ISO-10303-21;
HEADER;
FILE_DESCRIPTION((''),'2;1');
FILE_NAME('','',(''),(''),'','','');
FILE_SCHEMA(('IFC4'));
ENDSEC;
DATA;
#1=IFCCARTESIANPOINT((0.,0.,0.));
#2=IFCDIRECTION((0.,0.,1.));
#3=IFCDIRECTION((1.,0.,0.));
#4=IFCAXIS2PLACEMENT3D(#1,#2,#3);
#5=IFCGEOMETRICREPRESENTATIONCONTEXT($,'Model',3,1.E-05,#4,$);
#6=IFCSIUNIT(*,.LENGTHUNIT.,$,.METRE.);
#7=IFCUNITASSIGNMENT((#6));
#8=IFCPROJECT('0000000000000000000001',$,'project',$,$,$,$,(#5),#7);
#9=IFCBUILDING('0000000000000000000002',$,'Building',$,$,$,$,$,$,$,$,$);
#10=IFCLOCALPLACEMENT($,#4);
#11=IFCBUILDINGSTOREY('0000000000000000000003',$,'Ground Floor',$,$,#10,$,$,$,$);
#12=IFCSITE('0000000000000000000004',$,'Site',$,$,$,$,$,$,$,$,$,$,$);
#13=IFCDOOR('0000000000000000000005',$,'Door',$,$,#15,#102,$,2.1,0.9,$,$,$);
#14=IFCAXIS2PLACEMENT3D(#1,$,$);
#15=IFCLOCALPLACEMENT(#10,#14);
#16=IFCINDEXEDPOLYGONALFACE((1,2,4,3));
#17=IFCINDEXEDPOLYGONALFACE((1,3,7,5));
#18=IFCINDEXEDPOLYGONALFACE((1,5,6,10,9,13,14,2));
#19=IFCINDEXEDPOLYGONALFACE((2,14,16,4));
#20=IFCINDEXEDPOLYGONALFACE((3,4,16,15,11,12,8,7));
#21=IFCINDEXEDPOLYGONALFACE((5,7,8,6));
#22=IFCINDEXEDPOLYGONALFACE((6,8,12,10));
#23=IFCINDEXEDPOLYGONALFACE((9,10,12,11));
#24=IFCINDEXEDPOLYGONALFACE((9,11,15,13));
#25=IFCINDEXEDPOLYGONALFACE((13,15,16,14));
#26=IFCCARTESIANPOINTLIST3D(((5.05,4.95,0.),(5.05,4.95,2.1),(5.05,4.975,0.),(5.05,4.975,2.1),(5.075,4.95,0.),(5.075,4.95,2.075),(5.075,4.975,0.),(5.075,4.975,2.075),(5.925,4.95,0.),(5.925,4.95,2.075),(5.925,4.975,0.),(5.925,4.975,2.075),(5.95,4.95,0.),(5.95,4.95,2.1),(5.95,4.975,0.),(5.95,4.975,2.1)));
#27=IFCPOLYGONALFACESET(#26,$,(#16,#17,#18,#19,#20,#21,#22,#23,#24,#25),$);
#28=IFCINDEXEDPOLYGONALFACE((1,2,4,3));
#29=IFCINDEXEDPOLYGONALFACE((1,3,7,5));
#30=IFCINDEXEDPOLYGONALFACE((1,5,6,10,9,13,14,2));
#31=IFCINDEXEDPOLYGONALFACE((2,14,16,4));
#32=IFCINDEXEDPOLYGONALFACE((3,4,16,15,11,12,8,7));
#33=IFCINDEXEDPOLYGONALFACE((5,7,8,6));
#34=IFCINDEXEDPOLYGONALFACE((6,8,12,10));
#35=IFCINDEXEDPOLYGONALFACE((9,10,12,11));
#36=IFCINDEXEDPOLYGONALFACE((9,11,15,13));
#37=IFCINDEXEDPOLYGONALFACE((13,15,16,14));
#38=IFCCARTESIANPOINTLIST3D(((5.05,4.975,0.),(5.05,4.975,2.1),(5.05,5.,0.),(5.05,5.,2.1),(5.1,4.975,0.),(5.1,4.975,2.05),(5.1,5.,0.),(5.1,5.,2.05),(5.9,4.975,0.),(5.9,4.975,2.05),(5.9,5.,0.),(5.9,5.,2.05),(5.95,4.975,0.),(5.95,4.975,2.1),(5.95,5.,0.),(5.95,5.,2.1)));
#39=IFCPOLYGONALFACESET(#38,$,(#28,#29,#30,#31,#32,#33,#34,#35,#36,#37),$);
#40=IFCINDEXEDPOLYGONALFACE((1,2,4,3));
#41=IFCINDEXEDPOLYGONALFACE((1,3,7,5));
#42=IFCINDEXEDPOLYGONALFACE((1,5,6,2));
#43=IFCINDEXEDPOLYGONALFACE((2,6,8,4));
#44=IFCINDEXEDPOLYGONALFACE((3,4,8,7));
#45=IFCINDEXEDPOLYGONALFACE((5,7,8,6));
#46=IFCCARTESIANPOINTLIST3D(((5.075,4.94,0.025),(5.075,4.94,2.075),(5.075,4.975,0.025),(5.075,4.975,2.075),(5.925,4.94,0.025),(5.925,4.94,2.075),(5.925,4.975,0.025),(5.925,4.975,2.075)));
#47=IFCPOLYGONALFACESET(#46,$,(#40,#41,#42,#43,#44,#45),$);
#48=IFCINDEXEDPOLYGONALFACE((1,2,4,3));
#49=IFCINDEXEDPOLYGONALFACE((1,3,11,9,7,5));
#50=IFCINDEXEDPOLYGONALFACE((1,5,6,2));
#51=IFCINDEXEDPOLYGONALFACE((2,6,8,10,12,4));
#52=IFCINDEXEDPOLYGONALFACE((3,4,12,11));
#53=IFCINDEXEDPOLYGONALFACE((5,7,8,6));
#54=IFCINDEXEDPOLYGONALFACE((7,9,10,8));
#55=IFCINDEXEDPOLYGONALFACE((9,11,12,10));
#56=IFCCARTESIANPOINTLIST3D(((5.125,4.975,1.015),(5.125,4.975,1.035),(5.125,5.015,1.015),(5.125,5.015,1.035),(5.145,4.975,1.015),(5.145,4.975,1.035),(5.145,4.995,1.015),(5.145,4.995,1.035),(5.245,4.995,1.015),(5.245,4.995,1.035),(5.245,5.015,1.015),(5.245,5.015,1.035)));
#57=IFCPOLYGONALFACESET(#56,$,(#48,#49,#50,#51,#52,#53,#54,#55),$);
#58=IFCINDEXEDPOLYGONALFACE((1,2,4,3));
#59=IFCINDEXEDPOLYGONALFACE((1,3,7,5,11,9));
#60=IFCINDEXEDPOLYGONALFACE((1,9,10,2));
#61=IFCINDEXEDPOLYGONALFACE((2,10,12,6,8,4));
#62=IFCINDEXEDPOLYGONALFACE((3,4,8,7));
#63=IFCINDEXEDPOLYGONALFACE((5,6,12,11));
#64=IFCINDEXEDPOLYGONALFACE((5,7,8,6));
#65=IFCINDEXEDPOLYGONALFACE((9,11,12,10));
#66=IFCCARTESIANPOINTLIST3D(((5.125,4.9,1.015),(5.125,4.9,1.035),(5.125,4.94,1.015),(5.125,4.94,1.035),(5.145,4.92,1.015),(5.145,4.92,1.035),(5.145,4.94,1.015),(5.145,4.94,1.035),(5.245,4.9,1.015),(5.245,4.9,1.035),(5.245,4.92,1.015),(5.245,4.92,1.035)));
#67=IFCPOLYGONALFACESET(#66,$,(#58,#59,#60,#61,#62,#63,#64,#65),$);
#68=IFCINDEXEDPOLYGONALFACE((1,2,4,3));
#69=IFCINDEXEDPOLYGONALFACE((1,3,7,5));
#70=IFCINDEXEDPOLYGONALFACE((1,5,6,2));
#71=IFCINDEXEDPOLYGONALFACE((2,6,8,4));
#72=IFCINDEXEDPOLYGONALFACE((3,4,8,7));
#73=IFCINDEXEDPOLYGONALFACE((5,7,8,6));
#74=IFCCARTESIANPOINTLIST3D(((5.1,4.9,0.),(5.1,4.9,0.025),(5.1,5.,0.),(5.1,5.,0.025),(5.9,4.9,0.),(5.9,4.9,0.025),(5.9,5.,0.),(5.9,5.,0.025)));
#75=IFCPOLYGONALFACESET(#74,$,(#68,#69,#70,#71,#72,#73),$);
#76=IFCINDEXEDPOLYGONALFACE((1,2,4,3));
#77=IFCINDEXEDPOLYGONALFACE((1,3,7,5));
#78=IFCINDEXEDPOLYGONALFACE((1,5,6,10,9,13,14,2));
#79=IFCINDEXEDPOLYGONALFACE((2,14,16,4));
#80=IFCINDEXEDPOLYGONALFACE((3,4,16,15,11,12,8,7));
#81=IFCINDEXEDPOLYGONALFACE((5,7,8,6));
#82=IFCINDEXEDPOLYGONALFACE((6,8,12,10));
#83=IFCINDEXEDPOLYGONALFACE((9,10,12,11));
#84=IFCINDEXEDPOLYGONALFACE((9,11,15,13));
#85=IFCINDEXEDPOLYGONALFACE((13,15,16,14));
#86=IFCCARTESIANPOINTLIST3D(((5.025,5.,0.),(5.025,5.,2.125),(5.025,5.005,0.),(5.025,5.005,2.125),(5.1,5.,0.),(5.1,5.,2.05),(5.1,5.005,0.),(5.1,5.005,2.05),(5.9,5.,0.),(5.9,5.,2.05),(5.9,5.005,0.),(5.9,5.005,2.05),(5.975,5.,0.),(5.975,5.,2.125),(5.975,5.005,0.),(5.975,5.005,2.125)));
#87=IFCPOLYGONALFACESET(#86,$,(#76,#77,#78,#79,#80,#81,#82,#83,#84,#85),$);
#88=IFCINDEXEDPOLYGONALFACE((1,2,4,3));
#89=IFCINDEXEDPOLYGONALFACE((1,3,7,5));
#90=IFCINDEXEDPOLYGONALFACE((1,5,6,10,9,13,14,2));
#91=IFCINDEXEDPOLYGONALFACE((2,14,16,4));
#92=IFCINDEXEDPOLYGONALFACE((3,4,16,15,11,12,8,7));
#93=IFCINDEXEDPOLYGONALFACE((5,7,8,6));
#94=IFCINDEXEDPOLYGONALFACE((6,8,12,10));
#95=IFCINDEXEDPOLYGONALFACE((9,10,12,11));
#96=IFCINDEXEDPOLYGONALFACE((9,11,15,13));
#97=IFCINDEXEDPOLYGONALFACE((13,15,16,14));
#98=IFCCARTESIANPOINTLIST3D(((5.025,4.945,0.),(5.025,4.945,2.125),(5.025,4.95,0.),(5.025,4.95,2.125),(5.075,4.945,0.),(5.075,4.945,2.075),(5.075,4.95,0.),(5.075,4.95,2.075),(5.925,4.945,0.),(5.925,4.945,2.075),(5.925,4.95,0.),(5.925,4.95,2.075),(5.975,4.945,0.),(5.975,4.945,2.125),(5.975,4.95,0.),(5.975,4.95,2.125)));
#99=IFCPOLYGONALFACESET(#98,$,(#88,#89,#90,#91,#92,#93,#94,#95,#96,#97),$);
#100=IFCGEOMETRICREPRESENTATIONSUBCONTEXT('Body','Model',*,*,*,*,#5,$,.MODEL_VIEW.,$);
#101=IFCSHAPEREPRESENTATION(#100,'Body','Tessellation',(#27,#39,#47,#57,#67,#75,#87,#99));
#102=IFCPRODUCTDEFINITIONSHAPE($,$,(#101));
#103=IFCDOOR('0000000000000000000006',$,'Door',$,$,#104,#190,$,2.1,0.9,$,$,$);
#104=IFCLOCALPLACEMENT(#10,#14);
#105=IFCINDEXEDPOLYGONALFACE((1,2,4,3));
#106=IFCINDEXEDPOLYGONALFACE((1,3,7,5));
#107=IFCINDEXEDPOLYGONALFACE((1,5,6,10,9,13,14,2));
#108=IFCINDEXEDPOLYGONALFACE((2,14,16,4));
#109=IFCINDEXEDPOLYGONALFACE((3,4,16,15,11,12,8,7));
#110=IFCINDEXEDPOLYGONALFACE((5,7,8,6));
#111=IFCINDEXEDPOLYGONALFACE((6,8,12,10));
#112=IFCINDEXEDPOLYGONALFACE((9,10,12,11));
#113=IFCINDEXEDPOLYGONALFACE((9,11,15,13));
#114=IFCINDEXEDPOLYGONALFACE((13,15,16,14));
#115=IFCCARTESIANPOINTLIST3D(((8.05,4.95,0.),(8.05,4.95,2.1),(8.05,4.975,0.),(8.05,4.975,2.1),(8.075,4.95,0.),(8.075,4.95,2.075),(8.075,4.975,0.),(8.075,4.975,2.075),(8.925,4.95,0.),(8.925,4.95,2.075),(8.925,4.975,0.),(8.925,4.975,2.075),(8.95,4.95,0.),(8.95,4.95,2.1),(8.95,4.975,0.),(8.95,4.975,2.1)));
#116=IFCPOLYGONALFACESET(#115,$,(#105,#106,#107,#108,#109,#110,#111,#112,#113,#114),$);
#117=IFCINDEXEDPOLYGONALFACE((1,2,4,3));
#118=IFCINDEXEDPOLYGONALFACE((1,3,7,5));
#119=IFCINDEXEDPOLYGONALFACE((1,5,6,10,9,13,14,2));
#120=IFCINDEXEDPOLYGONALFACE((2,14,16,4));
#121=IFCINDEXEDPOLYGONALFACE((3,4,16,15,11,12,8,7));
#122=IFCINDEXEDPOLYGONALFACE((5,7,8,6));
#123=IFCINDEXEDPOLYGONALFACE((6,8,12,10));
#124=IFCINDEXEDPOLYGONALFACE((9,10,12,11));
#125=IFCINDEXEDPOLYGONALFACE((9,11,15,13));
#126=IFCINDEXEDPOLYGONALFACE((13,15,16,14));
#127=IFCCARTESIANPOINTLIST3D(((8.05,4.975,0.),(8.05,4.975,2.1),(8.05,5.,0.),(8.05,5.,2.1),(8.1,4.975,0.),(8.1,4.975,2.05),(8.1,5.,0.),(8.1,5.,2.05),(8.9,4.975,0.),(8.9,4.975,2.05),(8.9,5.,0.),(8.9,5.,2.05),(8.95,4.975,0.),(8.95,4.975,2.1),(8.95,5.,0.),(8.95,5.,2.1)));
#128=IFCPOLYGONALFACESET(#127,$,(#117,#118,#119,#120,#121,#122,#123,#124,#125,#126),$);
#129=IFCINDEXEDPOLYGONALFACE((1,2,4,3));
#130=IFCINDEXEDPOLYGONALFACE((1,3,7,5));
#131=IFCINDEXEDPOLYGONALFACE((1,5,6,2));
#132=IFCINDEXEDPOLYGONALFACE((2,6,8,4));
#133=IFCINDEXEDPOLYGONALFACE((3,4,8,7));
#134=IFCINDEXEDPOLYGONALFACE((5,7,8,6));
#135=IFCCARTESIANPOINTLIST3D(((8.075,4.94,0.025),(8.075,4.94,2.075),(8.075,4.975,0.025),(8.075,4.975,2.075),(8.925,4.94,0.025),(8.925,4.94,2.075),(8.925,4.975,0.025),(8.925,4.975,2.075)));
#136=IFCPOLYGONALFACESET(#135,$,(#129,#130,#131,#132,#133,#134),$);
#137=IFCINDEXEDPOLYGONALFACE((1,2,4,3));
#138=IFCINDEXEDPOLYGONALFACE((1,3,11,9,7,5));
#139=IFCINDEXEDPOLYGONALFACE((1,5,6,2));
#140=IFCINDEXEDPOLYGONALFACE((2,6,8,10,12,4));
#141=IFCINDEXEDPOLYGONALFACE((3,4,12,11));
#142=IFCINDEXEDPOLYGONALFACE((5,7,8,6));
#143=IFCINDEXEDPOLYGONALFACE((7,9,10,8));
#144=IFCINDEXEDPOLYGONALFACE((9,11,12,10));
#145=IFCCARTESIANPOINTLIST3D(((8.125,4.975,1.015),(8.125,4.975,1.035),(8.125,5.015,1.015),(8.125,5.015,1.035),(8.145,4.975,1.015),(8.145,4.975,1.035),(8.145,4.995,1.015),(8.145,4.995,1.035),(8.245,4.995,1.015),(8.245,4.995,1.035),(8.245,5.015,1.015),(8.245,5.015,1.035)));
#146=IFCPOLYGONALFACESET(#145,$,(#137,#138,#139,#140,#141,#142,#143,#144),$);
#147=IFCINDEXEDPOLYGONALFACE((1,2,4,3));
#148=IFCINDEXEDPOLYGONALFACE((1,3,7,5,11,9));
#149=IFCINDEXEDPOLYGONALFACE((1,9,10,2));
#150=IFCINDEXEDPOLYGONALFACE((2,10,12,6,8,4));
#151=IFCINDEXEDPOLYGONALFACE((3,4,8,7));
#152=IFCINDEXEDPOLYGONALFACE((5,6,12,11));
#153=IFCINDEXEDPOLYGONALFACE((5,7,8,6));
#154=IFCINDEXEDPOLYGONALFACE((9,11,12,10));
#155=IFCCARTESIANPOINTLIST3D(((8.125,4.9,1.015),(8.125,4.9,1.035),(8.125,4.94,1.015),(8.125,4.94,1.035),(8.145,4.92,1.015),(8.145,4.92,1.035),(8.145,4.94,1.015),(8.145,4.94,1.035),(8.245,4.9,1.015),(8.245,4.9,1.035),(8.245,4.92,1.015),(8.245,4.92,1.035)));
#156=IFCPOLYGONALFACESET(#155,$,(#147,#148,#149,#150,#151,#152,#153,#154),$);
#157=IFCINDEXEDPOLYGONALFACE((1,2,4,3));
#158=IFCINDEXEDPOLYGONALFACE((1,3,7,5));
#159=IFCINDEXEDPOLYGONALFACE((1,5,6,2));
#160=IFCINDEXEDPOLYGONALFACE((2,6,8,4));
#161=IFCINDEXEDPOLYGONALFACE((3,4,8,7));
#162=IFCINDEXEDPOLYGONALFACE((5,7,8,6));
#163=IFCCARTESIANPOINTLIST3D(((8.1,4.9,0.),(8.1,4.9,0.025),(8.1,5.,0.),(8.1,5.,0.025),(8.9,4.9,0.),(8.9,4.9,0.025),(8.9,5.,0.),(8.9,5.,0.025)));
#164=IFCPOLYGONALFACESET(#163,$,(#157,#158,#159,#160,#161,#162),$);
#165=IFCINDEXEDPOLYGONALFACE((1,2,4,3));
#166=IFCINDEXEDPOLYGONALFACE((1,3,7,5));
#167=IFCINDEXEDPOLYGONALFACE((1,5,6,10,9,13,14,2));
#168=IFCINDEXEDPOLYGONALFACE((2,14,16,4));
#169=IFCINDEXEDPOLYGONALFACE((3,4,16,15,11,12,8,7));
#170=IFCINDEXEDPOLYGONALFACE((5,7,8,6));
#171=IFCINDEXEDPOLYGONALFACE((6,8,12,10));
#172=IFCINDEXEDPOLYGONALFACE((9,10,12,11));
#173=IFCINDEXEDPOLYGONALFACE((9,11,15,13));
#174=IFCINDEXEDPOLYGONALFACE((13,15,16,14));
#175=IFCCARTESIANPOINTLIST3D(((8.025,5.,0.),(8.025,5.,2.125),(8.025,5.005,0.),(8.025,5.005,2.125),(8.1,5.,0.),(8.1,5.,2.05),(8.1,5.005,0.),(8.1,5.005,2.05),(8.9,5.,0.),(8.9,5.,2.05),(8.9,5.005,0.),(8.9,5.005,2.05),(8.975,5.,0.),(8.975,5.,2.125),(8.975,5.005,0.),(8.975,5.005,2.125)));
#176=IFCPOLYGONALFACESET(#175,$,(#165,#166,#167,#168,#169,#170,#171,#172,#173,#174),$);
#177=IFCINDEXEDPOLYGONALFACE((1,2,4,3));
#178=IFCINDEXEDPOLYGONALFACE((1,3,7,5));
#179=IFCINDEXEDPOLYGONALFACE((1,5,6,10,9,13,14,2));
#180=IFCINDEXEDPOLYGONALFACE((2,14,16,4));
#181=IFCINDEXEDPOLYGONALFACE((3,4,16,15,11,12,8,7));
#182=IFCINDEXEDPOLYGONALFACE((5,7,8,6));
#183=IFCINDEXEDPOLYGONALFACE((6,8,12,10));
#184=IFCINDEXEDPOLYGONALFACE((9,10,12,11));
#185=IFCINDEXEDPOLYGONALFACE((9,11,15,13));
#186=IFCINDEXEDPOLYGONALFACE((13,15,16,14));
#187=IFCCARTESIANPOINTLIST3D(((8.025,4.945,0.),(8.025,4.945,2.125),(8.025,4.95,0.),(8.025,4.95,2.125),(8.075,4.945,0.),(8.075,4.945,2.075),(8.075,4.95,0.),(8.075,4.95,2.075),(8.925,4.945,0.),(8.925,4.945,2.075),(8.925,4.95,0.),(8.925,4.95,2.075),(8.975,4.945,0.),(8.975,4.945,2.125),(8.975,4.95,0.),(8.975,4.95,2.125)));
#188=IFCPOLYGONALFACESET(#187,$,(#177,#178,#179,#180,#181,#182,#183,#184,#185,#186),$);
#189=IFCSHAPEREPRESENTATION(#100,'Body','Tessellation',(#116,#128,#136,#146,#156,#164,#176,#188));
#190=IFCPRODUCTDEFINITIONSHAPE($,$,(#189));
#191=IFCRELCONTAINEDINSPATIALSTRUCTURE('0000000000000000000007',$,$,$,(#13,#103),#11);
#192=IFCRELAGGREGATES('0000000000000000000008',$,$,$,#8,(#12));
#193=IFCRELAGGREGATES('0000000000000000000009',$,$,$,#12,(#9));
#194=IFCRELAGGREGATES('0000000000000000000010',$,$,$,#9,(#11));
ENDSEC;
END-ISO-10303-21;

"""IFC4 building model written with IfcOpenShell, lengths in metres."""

from ifc_helpers import new_model, si_unit, frame, origin_with_axes, place, context, subcontext, project, spatial, line, indexed_curve, outline, extrude, element, save


model = new_model("IFC4")

# Units and contexts
model_context = context("Model", 3, precision=1e-05, world=origin_with_axes())
body_context = subcontext(model_context, "Body", "Model", "MODEL_VIEW")
ifc_project = project(units=[si_unit("LENGTHUNIT", "METRE")], contexts=[model_context])

# Site, building, storey
site = spatial("IfcSite", under=ifc_project, Name="Site")
building = spatial("IfcBuilding", under=site, Name="Building")
storey_placement = place(None, origin_with_axes())
storey = spatial("IfcBuildingStorey", under=building, at=storey_placement, Name="Ground Floor")

# Doors
door_1_placement = place(storey_placement, frame((5.95, 5.0, 0.0), z_axis=(0.0, 0.0, 1.0), x_axis=(-1.0, 0.0, 0.0)))
element("IfcDoor", 1, at=door_1_placement, inside=storey, Name="Door", OverallHeight=2.1, OverallWidth=0.9, context=body_context, shape_type="SweptSolid", body=[
    extrude(outline(indexed_curve([(0.0, 0.0), (0.0, 2.1), (0.9, 2.1), (0.9, 0.0), (0.875, 0.0), (0.875, 2.075), (0.025, 2.075), (0.025, 0.0)], segments=[line(1, 2, 3, 4, 5, 6, 7, 8, 1)])), frame((0.0, 0.025, 0.0), z_axis=(0.0, -1.0, 0.0), x_axis=(1.0, 0.0, 0.0)), (0.0, 0.0, -1.0), 0.025),
    extrude(outline(indexed_curve([(0.0, 0.0), (0.0, 2.1), (0.9, 2.1), (0.9, 0.0), (0.85, 0.0), (0.85, 2.05), (0.05, 2.05), (0.05, 0.0)], segments=[line(1, 2, 3, 4, 5, 6, 7, 8, 1)])), frame((0.0, 0.0, 0.0), z_axis=(0.0, -1.0, 0.0), x_axis=(1.0, 0.0, 0.0)), (0.0, 0.0, -1.0), 0.025),
    extrude(outline(indexed_curve([(0.0, 0.0), (0.85, 0.0), (0.85, 0.035), (0.0, 0.035)], segments=[line(1, 2, 3, 4, 1)])), frame((0.025, 0.025, 0.025), z_axis=(0.0, 0.0, 1.0), x_axis=(1.0, 0.0, 0.0)), (0.0, 0.0, 1.0), 2.05),
    extrude(outline(indexed_curve([(0.0, 0.0), (0.0, -0.04), (-0.12, -0.04), (-0.12, -0.02), (-0.02, -0.02), (-0.02, 0.0)], segments=[line(1, 2, 3, 4, 5, 6, 1)])), frame((0.825, 0.025, 1.015), z_axis=(0.0, 0.0, 1.0), x_axis=(1.0, 0.0, 0.0)), (0.0, 0.0, 1.0), 0.02),
    extrude(outline(indexed_curve([(0.0, 0.0), (0.0, 0.04), (-0.12, 0.04), (-0.12, 0.02), (-0.02, 0.02), (-0.02, 0.0)], segments=[line(1, 2, 3, 4, 5, 6, 1)])), frame((0.825, 0.06, 1.015), z_axis=(0.0, 0.0, 1.0), x_axis=(1.0, 0.0, 0.0)), (0.0, 0.0, 1.0), 0.02),
    extrude(outline(indexed_curve([(0.0, 0.0), (0.8, 0.0), (0.8, 0.1), (0.0, 0.1)], segments=[line(1, 2, 3, 4, 1)])), frame((0.05, 0.0, 0.0), z_axis=(0.0, 0.0, 1.0), x_axis=(1.0, 0.0, 0.0)), (0.0, 0.0, 1.0), 0.025),
    extrude(outline(indexed_curve([(0.0, 0.0), (0.0, 2.125), (0.95, 2.125), (0.95, 0.0), (0.875, 0.0), (0.875, 2.05), (0.075, 2.05), (0.075, 0.0)], segments=[line(1, 2, 3, 4, 5, 6, 7, 8, 1)])), frame((-0.025, -0.005, 0.0), z_axis=(0.0, -1.0, 0.0), x_axis=(1.0, 0.0, 0.0)), (0.0, 0.0, -1.0), 0.005),
    extrude(outline(indexed_curve([(0.0, 0.0), (0.0, 2.125), (0.95, 2.125), (0.95, 0.0), (0.9, 0.0), (0.9, 2.075), (0.05, 2.075), (0.05, 0.0)], segments=[line(1, 2, 3, 4, 5, 6, 7, 8, 1)])), frame((-0.025, 0.05, 0.0), z_axis=(0.0, -1.0, 0.0), x_axis=(1.0, 0.0, 0.0)), (0.0, 0.0, -1.0), 0.005),
])
door_2_placement = place(storey_placement, frame((8.95, 5.0, 0.0), z_axis=(0.0, 0.0, 1.0), x_axis=(-1.0, 0.0, 0.0)))
element("IfcDoor", 2, at=door_2_placement, inside=storey, Name="Door", OverallHeight=2.1, OverallWidth=0.9, context=body_context, shape_type="SweptSolid", body=[
    extrude(outline(indexed_curve([(0.0, 0.0), (0.0, 2.1), (0.9, 2.1), (0.9, 0.0), (0.875, 0.0), (0.875, 2.075), (0.025, 2.075), (0.025, 0.0)], segments=[line(1, 2, 3, 4, 5, 6, 7, 8, 1)])), frame((0.0, 0.025, 0.0), z_axis=(0.0, -1.0, 0.0), x_axis=(1.0, 0.0, 0.0)), (0.0, 0.0, -1.0), 0.025),
    extrude(outline(indexed_curve([(0.0, 0.0), (0.0, 2.1), (0.9, 2.1), (0.9, 0.0), (0.85, 0.0), (0.85, 2.05), (0.05, 2.05), (0.05, 0.0)], segments=[line(1, 2, 3, 4, 5, 6, 7, 8, 1)])), frame((0.0, 0.0, 0.0), z_axis=(0.0, -1.0, 0.0), x_axis=(1.0, 0.0, 0.0)), (0.0, 0.0, -1.0), 0.025),
    extrude(outline(indexed_curve([(0.0, 0.0), (0.85, 0.0), (0.85, 0.035), (0.0, 0.035)], segments=[line(1, 2, 3, 4, 1)])), frame((0.025, 0.025, 0.025), z_axis=(0.0, 0.0, 1.0), x_axis=(1.0, 0.0, 0.0)), (0.0, 0.0, 1.0), 2.05),
    extrude(outline(indexed_curve([(0.0, 0.0), (0.0, -0.04), (-0.12, -0.04), (-0.12, -0.02), (-0.02, -0.02), (-0.02, 0.0)], segments=[line(1, 2, 3, 4, 5, 6, 1)])), frame((0.825, 0.025, 1.015), z_axis=(0.0, 0.0, 1.0), x_axis=(1.0, 0.0, 0.0)), (0.0, 0.0, 1.0), 0.02),
    extrude(outline(indexed_curve([(0.0, 0.0), (0.0, 0.04), (-0.12, 0.04), (-0.12, 0.02), (-0.02, 0.02), (-0.02, 0.0)], segments=[line(1, 2, 3, 4, 5, 6, 1)])), frame((0.825, 0.06, 1.015), z_axis=(0.0, 0.0, 1.0), x_axis=(1.0, 0.0, 0.0)), (0.0, 0.0, 1.0), 0.02),
    extrude(outline(indexed_curve([(0.0, 0.0), (0.8, 0.0), (0.8, 0.1), (0.0, 0.1)], segments=[line(1, 2, 3, 4, 1)])), frame((0.05, 0.0, 0.0), z_axis=(0.0, 0.0, 1.0), x_axis=(1.0, 0.0, 0.0)), (0.0, 0.0, 1.0), 0.025),
    extrude(outline(indexed_curve([(0.0, 0.0), (0.0, 2.125), (0.95, 2.125), (0.95, 0.0), (0.875, 0.0), (0.875, 2.05), (0.075, 2.05), (0.075, 0.0)], segments=[line(1, 2, 3, 4, 5, 6, 7, 8, 1)])), frame((-0.025, -0.005, 0.0), z_axis=(0.0, -1.0, 0.0), x_axis=(1.0, 0.0, 0.0)), (0.0, 0.0, -1.0), 0.005),
    extrude(outline(indexed_curve([(0.0, 0.0), (0.0, 2.125), (0.95, 2.125), (0.95, 0.0), (0.9, 0.0), (0.9, 2.075), (0.05, 2.075), (0.05, 0.0)], segments=[line(1, 2, 3, 4, 5, 6, 7, 8, 1)])), frame((-0.025, 0.05, 0.0), z_axis=(0.0, -1.0, 0.0), x_axis=(1.0, 0.0, 0.0)), (0.0, 0.0, -1.0), 0.005),
])

save(model, "model.ifc")
